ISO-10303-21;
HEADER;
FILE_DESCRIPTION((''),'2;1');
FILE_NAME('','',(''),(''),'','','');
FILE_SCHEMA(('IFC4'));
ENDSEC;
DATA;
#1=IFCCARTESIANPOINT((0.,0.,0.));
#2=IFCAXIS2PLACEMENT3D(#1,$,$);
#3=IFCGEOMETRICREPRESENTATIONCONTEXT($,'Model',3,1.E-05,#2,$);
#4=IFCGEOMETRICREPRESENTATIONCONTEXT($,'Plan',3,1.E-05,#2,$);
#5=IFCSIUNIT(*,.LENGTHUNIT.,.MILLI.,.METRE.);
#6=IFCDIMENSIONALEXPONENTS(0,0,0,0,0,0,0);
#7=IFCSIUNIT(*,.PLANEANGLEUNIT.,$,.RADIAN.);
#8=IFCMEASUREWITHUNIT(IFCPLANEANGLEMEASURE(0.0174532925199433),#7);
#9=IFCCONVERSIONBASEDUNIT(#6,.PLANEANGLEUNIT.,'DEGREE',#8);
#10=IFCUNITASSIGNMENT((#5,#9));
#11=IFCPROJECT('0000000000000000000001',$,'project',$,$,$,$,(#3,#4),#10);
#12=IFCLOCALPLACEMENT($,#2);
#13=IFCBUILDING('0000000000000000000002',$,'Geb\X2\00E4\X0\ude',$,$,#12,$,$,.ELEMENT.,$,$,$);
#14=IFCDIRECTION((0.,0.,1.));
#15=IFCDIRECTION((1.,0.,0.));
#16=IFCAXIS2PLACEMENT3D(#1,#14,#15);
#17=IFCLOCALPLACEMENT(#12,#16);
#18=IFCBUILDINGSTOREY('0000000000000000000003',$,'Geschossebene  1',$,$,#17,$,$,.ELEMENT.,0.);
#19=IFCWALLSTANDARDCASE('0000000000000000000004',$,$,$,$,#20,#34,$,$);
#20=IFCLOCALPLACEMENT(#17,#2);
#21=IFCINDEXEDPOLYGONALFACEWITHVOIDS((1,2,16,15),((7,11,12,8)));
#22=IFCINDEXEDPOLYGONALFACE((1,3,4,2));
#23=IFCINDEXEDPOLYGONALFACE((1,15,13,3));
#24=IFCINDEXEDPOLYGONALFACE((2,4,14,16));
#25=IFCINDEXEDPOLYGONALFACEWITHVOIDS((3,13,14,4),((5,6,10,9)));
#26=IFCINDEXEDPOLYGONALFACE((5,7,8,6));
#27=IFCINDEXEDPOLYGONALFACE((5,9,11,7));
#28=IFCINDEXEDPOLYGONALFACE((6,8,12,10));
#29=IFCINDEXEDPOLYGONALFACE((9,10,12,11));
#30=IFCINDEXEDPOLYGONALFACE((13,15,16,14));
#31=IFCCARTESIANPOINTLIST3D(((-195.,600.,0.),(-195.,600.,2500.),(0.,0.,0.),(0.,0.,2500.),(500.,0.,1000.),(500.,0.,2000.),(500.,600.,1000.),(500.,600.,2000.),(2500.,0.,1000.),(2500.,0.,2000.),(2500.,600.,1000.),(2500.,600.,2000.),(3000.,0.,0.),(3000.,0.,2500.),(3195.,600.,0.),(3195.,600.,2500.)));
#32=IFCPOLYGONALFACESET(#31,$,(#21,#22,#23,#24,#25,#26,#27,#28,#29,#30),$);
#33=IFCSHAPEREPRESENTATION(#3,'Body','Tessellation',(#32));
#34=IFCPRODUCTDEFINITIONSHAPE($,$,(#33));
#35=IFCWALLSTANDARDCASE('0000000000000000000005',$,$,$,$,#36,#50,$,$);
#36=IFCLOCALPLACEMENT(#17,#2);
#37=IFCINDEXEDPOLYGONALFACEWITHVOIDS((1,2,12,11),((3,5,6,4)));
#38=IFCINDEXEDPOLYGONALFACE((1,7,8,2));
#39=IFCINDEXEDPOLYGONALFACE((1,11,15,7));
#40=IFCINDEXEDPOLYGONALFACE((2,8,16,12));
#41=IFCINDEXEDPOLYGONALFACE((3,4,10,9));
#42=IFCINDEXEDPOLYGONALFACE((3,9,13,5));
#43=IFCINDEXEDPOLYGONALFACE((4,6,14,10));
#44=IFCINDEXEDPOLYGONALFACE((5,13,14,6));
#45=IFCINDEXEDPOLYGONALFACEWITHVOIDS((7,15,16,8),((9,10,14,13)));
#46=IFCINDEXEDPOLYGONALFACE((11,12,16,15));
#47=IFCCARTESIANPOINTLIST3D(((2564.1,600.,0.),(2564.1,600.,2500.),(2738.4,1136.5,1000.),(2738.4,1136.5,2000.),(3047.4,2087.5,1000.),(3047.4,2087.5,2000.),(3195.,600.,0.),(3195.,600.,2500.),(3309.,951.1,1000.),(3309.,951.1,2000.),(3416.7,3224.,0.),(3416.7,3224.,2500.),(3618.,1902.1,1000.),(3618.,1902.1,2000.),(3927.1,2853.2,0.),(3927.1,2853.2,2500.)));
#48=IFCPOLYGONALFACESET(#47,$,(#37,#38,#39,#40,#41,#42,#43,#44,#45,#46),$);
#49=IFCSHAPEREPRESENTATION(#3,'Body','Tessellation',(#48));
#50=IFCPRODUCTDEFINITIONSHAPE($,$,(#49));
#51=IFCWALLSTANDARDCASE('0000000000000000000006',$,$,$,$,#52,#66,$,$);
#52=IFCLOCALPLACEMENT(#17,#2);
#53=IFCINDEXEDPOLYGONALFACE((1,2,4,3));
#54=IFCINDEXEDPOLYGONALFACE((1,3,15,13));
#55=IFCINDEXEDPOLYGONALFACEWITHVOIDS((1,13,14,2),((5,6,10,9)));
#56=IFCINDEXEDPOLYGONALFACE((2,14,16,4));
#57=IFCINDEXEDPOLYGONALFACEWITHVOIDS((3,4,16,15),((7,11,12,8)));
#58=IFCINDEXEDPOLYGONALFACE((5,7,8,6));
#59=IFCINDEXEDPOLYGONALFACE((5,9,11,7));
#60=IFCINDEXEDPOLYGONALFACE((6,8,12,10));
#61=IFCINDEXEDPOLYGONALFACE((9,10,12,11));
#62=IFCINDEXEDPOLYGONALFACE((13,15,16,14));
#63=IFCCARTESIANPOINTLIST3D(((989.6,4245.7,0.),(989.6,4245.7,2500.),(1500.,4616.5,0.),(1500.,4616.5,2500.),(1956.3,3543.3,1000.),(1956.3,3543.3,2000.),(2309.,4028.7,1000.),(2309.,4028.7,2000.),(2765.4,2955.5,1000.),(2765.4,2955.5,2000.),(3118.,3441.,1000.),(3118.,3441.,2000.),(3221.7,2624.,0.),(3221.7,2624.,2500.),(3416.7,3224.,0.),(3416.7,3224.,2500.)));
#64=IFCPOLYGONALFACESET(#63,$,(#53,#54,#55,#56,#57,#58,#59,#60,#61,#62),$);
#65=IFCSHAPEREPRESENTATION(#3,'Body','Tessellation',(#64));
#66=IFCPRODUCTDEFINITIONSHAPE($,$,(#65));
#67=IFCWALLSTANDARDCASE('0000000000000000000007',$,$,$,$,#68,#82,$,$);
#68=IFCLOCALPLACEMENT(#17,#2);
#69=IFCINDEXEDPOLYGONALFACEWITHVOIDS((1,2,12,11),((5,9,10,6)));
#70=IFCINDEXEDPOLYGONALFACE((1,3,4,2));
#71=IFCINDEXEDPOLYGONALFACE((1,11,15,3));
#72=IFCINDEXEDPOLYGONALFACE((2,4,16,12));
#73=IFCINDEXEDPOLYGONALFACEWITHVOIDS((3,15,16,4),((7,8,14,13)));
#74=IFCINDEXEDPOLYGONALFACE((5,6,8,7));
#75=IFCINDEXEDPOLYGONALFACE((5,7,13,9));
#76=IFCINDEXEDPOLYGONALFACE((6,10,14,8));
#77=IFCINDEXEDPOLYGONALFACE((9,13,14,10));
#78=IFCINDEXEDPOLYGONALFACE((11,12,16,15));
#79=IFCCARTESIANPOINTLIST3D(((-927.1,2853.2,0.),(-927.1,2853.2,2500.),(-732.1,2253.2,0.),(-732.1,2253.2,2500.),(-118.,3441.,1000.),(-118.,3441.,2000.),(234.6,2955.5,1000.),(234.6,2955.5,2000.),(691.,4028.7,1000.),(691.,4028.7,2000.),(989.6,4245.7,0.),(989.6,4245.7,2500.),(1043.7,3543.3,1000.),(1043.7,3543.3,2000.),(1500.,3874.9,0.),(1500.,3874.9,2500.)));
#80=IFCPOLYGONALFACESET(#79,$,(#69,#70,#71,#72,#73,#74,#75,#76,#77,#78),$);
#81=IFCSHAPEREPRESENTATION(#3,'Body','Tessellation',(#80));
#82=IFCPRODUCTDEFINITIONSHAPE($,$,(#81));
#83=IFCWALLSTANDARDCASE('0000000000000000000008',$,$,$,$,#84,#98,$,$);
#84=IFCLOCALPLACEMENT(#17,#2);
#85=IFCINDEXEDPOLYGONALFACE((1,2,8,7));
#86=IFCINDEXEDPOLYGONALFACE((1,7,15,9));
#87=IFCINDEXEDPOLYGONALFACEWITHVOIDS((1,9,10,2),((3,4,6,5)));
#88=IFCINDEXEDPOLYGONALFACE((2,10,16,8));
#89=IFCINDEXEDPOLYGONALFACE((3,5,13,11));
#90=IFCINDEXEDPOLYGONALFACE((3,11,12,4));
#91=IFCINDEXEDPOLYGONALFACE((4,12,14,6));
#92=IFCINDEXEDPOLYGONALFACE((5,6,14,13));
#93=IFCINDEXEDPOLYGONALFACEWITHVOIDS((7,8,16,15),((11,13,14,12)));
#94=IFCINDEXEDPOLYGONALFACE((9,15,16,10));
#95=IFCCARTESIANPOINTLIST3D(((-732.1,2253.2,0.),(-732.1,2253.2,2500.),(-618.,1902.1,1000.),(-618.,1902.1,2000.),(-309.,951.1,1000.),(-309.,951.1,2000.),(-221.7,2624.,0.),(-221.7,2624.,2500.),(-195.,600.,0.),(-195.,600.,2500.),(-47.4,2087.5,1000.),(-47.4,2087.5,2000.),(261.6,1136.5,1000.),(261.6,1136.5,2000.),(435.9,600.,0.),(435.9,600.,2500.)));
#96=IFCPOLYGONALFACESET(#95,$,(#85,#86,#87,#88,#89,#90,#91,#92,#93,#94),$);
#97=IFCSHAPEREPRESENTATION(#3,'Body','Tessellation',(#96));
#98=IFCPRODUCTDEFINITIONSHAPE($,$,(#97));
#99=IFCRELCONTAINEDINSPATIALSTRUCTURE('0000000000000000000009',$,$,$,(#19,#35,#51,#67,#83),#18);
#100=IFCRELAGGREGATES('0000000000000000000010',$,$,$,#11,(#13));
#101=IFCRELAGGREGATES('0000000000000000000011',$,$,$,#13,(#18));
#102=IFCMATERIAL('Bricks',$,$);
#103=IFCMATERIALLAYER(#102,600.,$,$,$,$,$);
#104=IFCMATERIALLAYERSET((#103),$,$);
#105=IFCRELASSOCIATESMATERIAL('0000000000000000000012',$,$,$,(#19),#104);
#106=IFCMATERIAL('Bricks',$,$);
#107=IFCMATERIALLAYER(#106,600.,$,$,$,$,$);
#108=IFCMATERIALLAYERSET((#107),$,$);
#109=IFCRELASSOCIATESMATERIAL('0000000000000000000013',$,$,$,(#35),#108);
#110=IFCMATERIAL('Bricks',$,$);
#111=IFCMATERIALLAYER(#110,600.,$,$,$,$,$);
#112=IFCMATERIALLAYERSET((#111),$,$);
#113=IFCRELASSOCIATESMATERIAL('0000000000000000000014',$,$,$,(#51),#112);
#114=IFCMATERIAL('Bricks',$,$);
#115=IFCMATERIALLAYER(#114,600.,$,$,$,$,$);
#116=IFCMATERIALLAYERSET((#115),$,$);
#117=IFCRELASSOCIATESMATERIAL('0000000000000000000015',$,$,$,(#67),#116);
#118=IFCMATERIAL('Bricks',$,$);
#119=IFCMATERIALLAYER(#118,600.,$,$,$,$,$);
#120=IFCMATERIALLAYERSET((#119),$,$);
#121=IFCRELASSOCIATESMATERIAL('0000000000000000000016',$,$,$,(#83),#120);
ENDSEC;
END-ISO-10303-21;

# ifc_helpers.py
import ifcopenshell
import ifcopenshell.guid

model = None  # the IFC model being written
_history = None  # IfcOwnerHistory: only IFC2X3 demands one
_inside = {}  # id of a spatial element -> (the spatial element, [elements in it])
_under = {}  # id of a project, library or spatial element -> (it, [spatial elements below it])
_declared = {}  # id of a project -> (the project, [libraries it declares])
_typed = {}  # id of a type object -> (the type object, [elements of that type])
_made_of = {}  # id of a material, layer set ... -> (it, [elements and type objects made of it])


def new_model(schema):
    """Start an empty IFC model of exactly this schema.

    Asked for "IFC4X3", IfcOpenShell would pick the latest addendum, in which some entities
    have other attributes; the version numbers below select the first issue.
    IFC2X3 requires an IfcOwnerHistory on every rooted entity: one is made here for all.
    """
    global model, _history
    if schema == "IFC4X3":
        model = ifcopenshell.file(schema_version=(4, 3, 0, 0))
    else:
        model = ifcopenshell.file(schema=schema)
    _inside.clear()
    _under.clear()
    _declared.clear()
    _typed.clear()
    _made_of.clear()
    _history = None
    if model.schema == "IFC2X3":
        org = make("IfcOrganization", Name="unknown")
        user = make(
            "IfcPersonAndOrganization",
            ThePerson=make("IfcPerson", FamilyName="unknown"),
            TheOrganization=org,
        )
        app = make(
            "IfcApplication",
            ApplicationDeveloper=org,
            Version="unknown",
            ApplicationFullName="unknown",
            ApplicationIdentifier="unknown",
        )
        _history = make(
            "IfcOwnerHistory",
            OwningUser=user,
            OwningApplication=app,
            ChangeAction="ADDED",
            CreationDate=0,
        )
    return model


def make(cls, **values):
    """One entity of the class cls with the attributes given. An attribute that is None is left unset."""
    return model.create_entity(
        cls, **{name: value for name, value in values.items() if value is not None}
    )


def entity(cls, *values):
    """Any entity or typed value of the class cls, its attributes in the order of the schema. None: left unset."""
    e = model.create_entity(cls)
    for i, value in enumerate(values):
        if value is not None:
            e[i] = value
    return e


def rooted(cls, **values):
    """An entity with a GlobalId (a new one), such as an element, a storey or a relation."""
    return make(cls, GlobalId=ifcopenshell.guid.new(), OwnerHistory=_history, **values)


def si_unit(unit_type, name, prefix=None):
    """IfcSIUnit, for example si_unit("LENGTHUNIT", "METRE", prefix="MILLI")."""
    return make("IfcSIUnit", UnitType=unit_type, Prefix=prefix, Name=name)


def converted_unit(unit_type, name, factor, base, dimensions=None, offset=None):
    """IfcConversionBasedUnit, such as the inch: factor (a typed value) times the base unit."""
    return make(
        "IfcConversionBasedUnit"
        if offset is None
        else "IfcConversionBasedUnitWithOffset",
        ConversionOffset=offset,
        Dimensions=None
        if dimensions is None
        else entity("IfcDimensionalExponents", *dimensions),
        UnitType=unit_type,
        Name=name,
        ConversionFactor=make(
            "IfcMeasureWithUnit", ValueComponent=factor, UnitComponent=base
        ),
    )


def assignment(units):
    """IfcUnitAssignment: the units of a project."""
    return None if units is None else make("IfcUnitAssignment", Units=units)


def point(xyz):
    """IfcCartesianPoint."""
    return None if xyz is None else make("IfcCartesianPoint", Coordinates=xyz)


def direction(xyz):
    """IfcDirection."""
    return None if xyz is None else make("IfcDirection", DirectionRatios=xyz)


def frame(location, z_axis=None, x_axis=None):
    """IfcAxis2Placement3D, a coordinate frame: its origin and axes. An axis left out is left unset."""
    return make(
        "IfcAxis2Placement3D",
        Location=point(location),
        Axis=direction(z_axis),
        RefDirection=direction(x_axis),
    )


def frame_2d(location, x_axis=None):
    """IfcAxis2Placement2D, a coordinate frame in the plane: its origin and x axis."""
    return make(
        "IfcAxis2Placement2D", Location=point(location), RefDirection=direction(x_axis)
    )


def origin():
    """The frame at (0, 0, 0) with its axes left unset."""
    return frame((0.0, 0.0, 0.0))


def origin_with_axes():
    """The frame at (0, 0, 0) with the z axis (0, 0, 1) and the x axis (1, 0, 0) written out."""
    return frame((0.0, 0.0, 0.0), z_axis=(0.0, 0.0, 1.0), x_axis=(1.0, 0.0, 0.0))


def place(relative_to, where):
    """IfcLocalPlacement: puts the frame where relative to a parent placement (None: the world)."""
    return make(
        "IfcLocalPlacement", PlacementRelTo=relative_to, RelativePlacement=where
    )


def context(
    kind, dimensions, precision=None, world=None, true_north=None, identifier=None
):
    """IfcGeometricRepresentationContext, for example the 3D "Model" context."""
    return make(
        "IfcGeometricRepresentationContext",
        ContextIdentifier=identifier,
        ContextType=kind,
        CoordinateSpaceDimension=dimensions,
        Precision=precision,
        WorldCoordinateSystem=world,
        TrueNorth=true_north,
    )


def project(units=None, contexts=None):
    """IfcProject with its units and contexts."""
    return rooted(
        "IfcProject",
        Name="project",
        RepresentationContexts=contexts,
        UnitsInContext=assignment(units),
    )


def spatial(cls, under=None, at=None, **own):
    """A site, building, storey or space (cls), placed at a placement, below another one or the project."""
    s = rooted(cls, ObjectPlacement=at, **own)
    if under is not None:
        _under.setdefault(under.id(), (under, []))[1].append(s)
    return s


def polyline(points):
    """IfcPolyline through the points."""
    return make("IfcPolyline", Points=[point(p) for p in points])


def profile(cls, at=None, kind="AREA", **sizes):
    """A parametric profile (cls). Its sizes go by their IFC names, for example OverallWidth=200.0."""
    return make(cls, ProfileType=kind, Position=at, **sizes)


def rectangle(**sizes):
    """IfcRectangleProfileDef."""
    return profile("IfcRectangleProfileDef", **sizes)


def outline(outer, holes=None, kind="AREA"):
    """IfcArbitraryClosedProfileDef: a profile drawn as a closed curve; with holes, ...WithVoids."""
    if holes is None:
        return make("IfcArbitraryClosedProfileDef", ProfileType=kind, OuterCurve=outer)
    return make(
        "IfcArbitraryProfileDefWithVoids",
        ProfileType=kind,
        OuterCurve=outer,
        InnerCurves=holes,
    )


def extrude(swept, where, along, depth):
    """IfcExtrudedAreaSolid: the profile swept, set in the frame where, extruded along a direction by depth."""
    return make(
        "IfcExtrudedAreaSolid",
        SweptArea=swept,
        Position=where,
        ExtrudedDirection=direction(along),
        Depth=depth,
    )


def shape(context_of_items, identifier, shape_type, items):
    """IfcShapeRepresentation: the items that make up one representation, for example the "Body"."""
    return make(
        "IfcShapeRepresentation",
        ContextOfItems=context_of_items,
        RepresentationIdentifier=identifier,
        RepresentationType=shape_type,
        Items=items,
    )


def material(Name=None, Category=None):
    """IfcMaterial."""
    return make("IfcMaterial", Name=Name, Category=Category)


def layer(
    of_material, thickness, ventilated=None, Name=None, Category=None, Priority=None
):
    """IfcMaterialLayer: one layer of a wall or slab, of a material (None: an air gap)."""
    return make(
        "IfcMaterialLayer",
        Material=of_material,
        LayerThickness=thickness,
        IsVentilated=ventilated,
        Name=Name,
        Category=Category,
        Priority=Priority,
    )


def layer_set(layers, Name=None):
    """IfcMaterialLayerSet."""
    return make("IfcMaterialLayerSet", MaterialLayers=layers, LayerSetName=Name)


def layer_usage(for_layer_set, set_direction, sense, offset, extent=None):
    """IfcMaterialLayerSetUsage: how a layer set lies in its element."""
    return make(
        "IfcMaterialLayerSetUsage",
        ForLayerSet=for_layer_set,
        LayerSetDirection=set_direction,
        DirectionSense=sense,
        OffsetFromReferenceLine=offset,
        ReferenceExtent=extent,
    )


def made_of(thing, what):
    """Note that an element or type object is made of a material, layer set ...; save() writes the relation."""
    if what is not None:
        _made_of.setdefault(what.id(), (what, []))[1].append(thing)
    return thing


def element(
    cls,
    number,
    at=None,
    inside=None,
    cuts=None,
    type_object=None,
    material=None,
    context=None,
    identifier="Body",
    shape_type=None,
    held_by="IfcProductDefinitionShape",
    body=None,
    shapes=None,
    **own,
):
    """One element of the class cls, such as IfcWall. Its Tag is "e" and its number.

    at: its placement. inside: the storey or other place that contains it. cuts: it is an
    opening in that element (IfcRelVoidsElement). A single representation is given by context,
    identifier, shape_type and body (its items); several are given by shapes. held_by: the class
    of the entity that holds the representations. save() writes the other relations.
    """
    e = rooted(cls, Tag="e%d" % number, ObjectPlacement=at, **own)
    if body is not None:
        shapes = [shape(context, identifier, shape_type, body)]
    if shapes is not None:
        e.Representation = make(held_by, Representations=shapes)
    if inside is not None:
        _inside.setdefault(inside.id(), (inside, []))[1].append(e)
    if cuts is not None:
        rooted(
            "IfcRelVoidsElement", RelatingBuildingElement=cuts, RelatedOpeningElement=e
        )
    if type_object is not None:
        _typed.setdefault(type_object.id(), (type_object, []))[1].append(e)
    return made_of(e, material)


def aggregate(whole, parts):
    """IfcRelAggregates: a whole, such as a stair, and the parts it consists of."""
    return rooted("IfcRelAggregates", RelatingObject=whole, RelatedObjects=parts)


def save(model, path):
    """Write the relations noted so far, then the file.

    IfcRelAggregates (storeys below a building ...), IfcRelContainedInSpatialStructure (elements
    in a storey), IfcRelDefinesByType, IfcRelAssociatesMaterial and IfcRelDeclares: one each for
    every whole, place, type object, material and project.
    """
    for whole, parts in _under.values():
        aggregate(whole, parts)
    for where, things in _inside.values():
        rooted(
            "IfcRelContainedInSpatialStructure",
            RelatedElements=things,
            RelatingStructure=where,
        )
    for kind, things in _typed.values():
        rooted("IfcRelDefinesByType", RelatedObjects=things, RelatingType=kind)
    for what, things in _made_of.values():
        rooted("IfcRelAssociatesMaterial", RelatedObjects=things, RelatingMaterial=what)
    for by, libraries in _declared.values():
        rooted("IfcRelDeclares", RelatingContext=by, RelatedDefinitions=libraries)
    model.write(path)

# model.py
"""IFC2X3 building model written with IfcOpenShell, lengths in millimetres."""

from ifc_helpers import new_model, entity, si_unit, converted_unit, frame, frame_2d, origin, origin_with_axes, place, context, project, spatial, polyline, rectangle, outline, extrude, material, layer, layer_set, layer_usage, element, save


model = new_model("IFC2X3")

# Units and contexts
model_context = context("Model", 3, precision=1e-05, world=origin())
plan_context = context("Plan", 3, precision=1e-05, world=origin())
ifc_project = project(units=[si_unit("LENGTHUNIT", "METRE", prefix="MILLI"), converted_unit("PLANEANGLEUNIT", "DEGREE", entity("IfcPlaneAngleMeasure", 0.0174532925199433), si_unit("PLANEANGLEUNIT", "RADIAN"), dimensions=[0, 0, 0, 0, 0, 0, 0])], contexts=[model_context, plan_context])

# Building, storey
building_placement = place(None, origin())
building = spatial("IfcBuilding", under=ifc_project, at=building_placement, Name="Gebäude", CompositionType="ELEMENT")
storey_placement = place(building_placement, origin_with_axes())
storey = spatial("IfcBuildingStorey", under=building, at=storey_placement, Name="Geschossebene  1", CompositionType="ELEMENT", Elevation=0.0)

# Walls, openings
ifc_material_1 = material(Name="Bricks")
ifc_layer_1 = layer(ifc_material_1, 600.0)
ifc_layer_set_1 = layer_set([ifc_layer_1])
ifc_layer_usage_1 = layer_usage(ifc_layer_set_1, "AXIS2", "POSITIVE", -600.0)
wall_1_placement = place(storey_placement, frame((3195.0, 600.0, 0.0), z_axis=(0.0, 0.0, 1.0), x_axis=(-1.0, 0.0, 0.0)))
wall_1 = element("IfcWallStandardCase", 1, at=wall_1_placement, inside=storey, material=ifc_layer_usage_1, context=model_context, shape_type="SweptSolid", body=[
    extrude(outline(polyline([(0.0, 0.0), (3389.9, 0.0), (3195.0, 600.0), (195.0, 600.0), (0.0, 0.0)])), origin_with_axes(), (0.0, 0.0, 1.0), 2500.0),
])
opening_1_placement = place(wall_1_placement, frame((695.0, 0.0, 1000.0), z_axis=(0.0, 1.0, 0.0), x_axis=(0.0, 0.0, 1.0)))
element("IfcOpeningElement", 2, at=opening_1_placement, inside=storey, cuts=wall_1, ObjectType="Opening", context=model_context, shape_type="SweptSolid", body=[
    extrude(rectangle(XDim=1000.0, YDim=2000.0, at=frame_2d((500.0, 1000.0), x_axis=(1.0, 0.0))), origin_with_axes(), (0.0, 0.0, 1.0), 600.0),
])
ifc_material_2 = material(Name="Bricks")
ifc_layer_2 = layer(ifc_material_2, 600.0)
ifc_layer_set_2 = layer_set([ifc_layer_2])
ifc_layer_usage_2 = layer_usage(ifc_layer_set_2, "AXIS2", "POSITIVE", -600.0)
wall_2_placement = place(storey_placement, frame((3416.7, 3224.0, 0.0), z_axis=(0.0, 0.0, 1.0), x_axis=(-0.309017, -0.951057, 0.0)))
wall_2 = element("IfcWallStandardCase", 3, at=wall_2_placement, inside=storey, material=ifc_layer_usage_2, context=model_context, shape_type="SweptSolid", body=[
    extrude(outline(polyline([(0.0, 0.0), (2759.0, 0.0), (2564.1, 600.0), (195.0, 600.0), (0.0, 0.0)])), origin_with_axes(), (0.0, 0.0, 1.0), 2500.0),
])
opening_2_placement = place(wall_2_placement, frame((1195.0, 0.0, 1000.0), z_axis=(0.0, 1.0, 0.0), x_axis=(0.0, 0.0, 1.0)))
element("IfcOpeningElement", 4, at=opening_2_placement, inside=storey, cuts=wall_2, ObjectType="Opening", context=model_context, shape_type="SweptSolid", body=[
    extrude(rectangle(XDim=1000.0, YDim=1000.0, at=frame_2d((500.0, 500.0), x_axis=(1.0, 0.0))), origin_with_axes(), (0.0, 0.0, 1.0), 600.0),
])
ifc_material_3 = material(Name="Bricks")
ifc_layer_3 = layer(ifc_material_3, 600.0)
ifc_layer_set_3 = layer_set([ifc_layer_3])
ifc_layer_usage_3 = layer_usage(ifc_layer_set_3, "AXIS2", "POSITIVE", -600.0)
wall_3_placement = place(storey_placement, frame((989.6, 4245.7, 0.0), z_axis=(0.0, 0.0, 1.0), x_axis=(0.809017, -0.587785, 0.0)))
wall_3 = element("IfcWallStandardCase", 5, at=wall_3_placement, inside=storey, material=ifc_layer_usage_3, context=model_context, shape_type="SweptSolid", body=[
    extrude(outline(polyline([(0.0, 0.0), (2759.0, 0.0), (2564.1, 600.0), (195.0, 600.0), (0.0, 0.0)])), origin_with_axes(), (0.0, 0.0, 1.0), 2500.0),
])
opening_3_placement = place(wall_3_placement, frame((1195.0, 0.0, 1000.0), z_axis=(0.0, 1.0, 0.0), x_axis=(0.0, 0.0, 1.0)))
element("IfcOpeningElement", 6, at=opening_3_placement, inside=storey, cuts=wall_3, ObjectType="Opening", context=model_context, shape_type="SweptSolid", body=[
    extrude(rectangle(XDim=1000.0, YDim=1000.0, at=frame_2d((500.0, 500.0), x_axis=(1.0, 0.0))), origin_with_axes(), (0.0, 0.0, 1.0), 600.0),
])
ifc_material_4 = material(Name="Bricks")
ifc_layer_4 = layer(ifc_material_4, 600.0)
ifc_layer_set_4 = layer_set([ifc_layer_4])
ifc_layer_usage_4 = layer_usage(ifc_layer_set_4, "AXIS2", "POSITIVE", -600.0)
wall_4_placement = place(storey_placement, frame((-732.1, 2253.2, 0.0), z_axis=(0.0, 0.0, 1.0), x_axis=(0.809017, 0.587785, 0.0)))
wall_4 = element("IfcWallStandardCase", 7, at=wall_4_placement, inside=storey, material=ifc_layer_usage_4, context=model_context, shape_type="SweptSolid", body=[
    extrude(outline(polyline([(0.0, 0.0), (2759.0, 0.0), (2564.1, 600.0), (195.0, 600.0), (0.0, 0.0)])), origin_with_axes(), (0.0, 0.0, 1.0), 2500.0),
])
opening_4_placement = place(wall_4_placement, frame((1195.0, 0.0, 1000.0), z_axis=(0.0, 1.0, 0.0), x_axis=(0.0, 0.0, 1.0)))
element("IfcOpeningElement", 8, at=opening_4_placement, inside=storey, cuts=wall_4, ObjectType="Opening", context=model_context, shape_type="SweptSolid", body=[
    extrude(rectangle(XDim=1000.0, YDim=1000.0, at=frame_2d((500.0, 500.0), x_axis=(1.0, 0.0))), origin_with_axes(), (0.0, 0.0, 1.0), 600.0),
])
ifc_material_5 = material(Name="Bricks")
ifc_layer_5 = layer(ifc_material_5, 600.0)
ifc_layer_set_5 = layer_set([ifc_layer_5])
ifc_layer_usage_5 = layer_usage(ifc_layer_set_5, "AXIS2", "POSITIVE", -600.0)
wall_5_placement = place(storey_placement, frame((435.9, 600.0, 0.0), z_axis=(0.0, 0.0, 1.0), x_axis=(-0.309017, 0.951057, 0.0)))
wall_5 = element("IfcWallStandardCase", 9, at=wall_5_placement, inside=storey, material=ifc_layer_usage_5, context=model_context, shape_type="SweptSolid", body=[
    extrude(outline(polyline([(0.0, 0.0), (2128.1, 0.0), (1933.2, 600.0), (195.0, 600.0), (0.0, 0.0)])), origin_with_axes(), (0.0, 0.0, 1.0), 2500.0),
])
opening_5_placement = place(wall_5_placement, frame((564.1, 0.0, 1000.0), z_axis=(0.0, 1.0, 0.0), x_axis=(0.0, 0.0, 1.0)))
element("IfcOpeningElement", 10, at=opening_5_placement, inside=storey, cuts=wall_5, ObjectType="Opening", context=model_context, shape_type="SweptSolid", body=[
    extrude(rectangle(XDim=1000.0, YDim=1000.0, at=frame_2d((500.0, 500.0), x_axis=(1.0, 0.0))), origin_with_axes(), (0.0, 0.0, 1.0), 600.0),
])

save(model, "model.ifc")
